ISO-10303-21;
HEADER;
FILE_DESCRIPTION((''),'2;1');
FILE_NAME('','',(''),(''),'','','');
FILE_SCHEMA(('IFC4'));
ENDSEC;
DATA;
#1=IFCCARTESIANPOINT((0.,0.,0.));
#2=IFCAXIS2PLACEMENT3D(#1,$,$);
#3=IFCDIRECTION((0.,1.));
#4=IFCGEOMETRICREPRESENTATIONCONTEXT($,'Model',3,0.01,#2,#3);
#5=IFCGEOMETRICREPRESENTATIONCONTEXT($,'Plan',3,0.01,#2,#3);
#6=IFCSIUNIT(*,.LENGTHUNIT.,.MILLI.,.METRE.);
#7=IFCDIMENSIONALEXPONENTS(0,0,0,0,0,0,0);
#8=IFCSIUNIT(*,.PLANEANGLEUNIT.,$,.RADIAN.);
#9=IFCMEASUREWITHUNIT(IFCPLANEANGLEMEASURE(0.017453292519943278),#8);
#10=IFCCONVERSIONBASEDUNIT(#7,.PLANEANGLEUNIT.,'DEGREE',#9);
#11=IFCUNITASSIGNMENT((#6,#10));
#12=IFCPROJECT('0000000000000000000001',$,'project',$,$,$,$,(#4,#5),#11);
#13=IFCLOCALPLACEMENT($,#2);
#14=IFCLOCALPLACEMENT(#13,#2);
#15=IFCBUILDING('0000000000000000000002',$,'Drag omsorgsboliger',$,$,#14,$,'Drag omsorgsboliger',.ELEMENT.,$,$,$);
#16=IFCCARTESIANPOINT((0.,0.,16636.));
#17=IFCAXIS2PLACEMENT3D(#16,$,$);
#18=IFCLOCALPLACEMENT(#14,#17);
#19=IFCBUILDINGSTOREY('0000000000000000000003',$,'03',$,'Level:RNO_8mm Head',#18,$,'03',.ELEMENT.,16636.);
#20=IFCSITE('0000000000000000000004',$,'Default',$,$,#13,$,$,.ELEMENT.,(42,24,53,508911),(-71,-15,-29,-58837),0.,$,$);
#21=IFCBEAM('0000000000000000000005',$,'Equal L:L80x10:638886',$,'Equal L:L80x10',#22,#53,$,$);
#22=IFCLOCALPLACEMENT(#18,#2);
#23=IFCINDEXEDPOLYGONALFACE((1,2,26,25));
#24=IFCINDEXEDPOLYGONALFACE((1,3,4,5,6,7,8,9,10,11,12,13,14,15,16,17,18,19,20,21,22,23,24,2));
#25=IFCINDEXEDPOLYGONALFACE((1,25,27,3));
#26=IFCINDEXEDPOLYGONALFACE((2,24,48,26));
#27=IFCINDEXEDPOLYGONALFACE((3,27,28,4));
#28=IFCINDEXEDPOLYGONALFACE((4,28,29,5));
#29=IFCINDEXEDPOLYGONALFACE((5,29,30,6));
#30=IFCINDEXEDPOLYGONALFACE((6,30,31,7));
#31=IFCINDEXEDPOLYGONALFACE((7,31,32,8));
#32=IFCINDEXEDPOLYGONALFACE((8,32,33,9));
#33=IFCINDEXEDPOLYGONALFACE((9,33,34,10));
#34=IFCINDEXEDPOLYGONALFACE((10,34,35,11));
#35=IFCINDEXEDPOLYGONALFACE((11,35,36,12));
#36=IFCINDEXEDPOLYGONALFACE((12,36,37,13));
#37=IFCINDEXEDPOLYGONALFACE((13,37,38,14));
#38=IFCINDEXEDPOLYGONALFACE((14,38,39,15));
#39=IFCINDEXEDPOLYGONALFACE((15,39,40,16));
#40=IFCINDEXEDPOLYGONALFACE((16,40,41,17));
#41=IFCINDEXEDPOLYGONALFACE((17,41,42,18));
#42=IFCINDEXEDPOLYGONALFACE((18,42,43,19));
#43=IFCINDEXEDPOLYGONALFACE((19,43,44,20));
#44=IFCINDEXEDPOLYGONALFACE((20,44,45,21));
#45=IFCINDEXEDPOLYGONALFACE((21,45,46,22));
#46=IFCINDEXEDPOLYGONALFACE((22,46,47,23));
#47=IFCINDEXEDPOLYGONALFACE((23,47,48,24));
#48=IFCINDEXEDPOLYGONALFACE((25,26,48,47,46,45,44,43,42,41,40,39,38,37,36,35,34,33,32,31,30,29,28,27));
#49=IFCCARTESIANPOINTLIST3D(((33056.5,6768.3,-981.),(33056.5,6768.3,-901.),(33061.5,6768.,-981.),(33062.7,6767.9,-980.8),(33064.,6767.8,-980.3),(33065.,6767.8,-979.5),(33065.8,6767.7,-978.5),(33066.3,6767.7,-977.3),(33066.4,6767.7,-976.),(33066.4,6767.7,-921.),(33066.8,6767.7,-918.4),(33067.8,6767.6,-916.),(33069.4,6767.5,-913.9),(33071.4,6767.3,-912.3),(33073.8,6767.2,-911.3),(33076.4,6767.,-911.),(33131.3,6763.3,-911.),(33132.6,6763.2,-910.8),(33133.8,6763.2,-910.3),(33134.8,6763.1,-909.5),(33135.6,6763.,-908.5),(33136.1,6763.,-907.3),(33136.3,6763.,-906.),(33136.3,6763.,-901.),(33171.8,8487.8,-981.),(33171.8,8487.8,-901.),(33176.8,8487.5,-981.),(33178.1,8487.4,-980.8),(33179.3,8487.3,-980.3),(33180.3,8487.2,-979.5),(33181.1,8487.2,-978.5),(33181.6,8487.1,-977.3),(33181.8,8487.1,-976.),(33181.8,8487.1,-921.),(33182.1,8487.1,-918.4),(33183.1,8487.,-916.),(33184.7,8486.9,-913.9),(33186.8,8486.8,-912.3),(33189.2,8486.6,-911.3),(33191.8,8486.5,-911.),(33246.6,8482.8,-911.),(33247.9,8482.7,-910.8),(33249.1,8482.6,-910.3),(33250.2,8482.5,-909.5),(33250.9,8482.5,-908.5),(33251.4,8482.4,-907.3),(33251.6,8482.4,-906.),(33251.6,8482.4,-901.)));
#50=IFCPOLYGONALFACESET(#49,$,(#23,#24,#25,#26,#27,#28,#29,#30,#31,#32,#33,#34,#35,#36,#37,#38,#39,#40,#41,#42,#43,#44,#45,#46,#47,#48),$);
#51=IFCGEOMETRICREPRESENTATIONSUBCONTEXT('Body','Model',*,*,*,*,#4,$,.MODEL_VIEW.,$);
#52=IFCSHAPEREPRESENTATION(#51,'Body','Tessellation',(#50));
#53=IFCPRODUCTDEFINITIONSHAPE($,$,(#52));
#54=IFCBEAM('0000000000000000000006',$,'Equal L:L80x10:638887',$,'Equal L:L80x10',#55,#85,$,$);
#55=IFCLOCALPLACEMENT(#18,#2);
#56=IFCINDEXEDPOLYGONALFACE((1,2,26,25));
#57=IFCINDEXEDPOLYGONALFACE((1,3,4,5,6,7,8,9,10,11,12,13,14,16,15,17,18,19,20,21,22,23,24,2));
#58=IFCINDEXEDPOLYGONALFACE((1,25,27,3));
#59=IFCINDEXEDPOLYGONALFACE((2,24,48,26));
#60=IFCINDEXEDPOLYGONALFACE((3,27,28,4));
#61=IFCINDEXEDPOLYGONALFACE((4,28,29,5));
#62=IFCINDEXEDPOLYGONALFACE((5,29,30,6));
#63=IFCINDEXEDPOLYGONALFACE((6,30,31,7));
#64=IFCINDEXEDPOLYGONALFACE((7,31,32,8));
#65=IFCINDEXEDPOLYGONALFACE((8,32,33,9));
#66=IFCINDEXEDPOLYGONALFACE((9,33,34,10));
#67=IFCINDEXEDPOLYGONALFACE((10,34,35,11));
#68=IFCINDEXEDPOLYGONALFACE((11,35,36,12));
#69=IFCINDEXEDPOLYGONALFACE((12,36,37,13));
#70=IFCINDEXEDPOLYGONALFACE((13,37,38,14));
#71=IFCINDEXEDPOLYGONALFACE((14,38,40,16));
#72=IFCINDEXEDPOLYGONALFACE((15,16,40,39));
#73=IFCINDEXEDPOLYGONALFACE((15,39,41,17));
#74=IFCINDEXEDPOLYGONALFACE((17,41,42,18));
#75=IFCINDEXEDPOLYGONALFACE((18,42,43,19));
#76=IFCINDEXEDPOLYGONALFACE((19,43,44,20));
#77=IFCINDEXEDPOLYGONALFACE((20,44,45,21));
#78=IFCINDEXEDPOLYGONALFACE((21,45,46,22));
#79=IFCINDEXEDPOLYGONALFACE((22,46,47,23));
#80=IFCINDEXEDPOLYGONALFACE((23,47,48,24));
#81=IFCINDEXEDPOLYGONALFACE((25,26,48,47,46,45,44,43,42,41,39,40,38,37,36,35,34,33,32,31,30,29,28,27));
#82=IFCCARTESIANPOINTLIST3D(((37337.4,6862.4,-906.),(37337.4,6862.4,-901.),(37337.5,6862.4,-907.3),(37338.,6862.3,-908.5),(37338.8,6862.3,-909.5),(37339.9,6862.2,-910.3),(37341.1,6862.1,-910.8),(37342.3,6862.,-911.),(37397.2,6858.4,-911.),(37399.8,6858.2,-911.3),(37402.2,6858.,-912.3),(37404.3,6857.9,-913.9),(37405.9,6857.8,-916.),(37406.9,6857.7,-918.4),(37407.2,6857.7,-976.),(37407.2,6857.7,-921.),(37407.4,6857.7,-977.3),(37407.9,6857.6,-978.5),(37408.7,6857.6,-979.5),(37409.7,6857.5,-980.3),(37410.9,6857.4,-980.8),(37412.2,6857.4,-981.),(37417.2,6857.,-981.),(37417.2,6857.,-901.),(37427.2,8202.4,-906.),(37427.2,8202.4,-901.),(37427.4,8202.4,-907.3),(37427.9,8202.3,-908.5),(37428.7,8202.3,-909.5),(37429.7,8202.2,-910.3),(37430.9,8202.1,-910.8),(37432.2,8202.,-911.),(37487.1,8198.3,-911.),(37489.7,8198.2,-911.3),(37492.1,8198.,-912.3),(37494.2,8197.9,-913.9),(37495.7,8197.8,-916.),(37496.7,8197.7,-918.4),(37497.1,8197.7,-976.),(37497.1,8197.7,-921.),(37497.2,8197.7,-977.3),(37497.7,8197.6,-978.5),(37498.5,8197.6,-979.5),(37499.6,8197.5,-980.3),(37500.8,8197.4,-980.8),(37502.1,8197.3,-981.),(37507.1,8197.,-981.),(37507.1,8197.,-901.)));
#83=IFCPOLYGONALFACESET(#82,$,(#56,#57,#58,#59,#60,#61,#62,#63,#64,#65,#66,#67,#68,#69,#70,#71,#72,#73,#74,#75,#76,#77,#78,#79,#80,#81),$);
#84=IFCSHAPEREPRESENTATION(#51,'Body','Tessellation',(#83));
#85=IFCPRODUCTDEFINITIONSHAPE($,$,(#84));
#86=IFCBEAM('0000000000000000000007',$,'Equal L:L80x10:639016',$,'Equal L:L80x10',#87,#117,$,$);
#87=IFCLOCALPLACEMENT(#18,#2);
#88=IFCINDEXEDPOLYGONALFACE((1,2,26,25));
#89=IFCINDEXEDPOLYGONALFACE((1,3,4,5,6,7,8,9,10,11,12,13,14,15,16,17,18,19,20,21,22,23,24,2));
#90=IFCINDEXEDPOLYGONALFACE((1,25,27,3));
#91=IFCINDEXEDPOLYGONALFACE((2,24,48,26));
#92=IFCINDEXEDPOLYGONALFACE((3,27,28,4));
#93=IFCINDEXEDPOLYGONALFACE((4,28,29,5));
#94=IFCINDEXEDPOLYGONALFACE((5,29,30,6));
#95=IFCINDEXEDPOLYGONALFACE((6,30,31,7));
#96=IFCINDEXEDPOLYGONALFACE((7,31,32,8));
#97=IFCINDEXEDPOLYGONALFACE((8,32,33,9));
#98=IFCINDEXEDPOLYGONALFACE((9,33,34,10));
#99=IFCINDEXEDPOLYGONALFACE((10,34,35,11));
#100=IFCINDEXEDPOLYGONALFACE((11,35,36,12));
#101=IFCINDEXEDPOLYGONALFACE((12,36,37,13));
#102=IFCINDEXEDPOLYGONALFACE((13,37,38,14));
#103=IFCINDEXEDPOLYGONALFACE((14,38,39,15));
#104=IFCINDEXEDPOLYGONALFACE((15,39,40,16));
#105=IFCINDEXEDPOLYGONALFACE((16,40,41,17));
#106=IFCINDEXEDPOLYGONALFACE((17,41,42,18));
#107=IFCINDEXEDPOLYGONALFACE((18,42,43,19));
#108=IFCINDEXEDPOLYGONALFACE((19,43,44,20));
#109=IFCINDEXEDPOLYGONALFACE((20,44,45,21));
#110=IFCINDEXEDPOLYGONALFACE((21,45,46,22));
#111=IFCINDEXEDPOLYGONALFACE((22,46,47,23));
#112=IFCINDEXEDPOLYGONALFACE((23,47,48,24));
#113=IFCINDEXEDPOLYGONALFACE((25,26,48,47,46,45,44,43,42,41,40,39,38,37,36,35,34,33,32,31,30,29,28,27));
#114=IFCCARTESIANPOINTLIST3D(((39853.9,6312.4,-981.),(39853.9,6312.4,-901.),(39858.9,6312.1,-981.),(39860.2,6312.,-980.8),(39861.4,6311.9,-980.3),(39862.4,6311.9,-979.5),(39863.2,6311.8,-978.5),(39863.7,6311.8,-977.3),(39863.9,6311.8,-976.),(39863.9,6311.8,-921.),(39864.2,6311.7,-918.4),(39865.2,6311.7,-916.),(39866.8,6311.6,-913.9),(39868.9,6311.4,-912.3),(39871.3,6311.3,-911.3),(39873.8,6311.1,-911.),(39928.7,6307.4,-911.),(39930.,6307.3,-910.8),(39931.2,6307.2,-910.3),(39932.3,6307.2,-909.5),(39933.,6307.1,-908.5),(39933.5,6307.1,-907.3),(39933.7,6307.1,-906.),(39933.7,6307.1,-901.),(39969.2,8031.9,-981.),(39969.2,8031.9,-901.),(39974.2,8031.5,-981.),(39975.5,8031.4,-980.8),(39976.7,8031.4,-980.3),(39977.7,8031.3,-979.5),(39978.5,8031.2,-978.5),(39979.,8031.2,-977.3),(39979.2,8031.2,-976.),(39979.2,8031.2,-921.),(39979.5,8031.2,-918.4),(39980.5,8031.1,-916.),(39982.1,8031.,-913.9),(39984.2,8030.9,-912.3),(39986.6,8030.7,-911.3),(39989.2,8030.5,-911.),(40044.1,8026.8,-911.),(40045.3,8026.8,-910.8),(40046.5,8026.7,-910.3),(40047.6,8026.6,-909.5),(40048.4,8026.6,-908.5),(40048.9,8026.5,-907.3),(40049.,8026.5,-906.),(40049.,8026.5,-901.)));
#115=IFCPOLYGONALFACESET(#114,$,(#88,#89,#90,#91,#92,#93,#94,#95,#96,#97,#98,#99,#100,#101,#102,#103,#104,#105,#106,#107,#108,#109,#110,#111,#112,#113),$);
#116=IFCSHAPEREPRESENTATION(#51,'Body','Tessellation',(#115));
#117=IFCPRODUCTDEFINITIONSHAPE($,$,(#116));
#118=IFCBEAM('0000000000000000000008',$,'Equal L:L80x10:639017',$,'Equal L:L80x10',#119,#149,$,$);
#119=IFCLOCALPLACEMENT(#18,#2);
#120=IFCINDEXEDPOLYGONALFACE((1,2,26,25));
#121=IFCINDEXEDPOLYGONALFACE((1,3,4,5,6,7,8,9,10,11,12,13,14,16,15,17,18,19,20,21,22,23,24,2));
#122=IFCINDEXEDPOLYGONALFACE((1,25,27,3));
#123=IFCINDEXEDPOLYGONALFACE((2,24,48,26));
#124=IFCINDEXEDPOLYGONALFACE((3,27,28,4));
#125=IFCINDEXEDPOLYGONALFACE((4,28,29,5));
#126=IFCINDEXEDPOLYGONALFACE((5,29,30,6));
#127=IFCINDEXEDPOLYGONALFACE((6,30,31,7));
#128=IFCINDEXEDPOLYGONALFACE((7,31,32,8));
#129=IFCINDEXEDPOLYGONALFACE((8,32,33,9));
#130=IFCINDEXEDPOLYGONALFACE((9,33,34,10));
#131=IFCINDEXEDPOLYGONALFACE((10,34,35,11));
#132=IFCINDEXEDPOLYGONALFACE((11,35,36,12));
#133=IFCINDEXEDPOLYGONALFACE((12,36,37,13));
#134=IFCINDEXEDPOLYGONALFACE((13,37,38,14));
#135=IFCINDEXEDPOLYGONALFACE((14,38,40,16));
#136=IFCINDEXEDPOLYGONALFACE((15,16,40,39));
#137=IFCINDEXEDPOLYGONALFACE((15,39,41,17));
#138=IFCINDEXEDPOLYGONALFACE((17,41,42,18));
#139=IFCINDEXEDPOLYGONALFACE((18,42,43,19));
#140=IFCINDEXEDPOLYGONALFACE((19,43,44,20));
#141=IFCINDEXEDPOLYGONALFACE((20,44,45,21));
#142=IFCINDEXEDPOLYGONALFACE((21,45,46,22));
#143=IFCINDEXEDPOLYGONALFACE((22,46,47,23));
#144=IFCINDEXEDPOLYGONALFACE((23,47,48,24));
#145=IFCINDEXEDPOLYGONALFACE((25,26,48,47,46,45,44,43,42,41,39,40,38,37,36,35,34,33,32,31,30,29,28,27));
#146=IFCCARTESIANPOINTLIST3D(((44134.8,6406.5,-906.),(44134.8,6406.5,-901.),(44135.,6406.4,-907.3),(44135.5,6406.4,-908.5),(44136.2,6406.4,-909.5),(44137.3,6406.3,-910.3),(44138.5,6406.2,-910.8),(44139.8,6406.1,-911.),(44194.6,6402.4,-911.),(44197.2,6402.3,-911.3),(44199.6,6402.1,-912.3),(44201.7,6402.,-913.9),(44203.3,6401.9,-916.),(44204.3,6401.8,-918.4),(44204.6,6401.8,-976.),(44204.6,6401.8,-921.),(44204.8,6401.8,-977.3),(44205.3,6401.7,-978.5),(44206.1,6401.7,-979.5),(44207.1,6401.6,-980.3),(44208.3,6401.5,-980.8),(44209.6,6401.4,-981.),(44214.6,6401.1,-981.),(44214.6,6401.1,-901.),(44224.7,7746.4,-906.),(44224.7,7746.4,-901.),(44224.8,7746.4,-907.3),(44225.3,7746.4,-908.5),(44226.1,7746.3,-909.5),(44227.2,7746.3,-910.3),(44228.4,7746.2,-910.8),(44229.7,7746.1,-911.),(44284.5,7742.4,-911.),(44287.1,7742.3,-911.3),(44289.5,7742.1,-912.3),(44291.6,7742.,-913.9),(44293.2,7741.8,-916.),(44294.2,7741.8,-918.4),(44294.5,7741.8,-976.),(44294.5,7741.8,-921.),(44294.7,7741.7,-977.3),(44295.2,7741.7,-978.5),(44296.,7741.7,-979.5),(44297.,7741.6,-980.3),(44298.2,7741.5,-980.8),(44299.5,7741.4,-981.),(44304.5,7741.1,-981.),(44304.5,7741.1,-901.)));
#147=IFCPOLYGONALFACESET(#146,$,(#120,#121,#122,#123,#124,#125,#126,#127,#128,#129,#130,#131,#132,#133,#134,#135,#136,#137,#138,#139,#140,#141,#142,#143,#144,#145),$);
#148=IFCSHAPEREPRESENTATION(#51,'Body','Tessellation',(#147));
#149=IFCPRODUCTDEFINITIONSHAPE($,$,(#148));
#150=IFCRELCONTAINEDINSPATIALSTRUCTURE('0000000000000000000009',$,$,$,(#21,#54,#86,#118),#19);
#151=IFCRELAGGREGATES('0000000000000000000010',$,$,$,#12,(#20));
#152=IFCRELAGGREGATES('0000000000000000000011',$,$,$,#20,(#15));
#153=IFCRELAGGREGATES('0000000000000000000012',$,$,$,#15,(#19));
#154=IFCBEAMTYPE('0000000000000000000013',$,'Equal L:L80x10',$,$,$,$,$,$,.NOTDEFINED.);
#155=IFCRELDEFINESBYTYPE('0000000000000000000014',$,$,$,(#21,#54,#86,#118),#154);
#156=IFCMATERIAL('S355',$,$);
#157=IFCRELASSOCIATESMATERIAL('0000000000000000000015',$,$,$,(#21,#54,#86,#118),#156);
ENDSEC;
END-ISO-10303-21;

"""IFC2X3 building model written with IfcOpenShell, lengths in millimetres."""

from ifc_helpers import new_model, entity, si_unit, converted_unit, direction, frame, frame_2d, origin, place, context, subcontext, project, spatial, polyline, circle_curve, parameter, trimmed, segment, composite_curve, outline, extrude, material, type_object, element, save


model = new_model("IFC2X3")

# Units and contexts
model_context = context("Model", 3, precision=0.01, world=origin(), true_north=direction((0.0, 1.0)))
plan_context = context("Plan", 3, precision=0.01, world=origin(), true_north=direction((0.0, 1.0)))
body_context = subcontext(model_context, "Body", "Model", "MODEL_VIEW")
ifc_project = project(units=[si_unit("LENGTHUNIT", "METRE", prefix="MILLI"), converted_unit("PLANEANGLEUNIT", "DEGREE", entity("IfcPlaneAngleMeasure", 0.017453292519943278), si_unit("PLANEANGLEUNIT", "RADIAN"), dimensions=[0, 0, 0, 0, 0, 0, 0])], contexts=[model_context, plan_context])

# Site, building, storey
site_placement = place(None, origin())
site = spatial("IfcSite", under=ifc_project, at=site_placement, Name="Default", CompositionType="ELEMENT", RefLatitude=(42, 24, 53, 508911), RefLongitude=(-71, -15, -29, -58837), RefElevation=0.0)
building_placement = place(site_placement, origin())
building = spatial("IfcBuilding", under=site, at=building_placement, Name="Drag omsorgsboliger", LongName="Drag omsorgsboliger", CompositionType="ELEMENT")
storey_placement = place(building_placement, frame((0.0, 0.0, 16636.0)))
storey = spatial("IfcBuildingStorey", under=building, at=storey_placement, Name="03", ObjectType="Level:RNO_8mm Head", LongName="03", CompositionType="ELEMENT", Elevation=16636.0)

# Beams
ifc_material = material(Name="S355")
beam_type_1 = type_object("IfcBeamType", Name="Equal L:L80x10", PredefinedType="NOTDEFINED")
beam_1_placement = place(storey_placement, frame((33190.5, 8416.4, -981.0), z_axis=(0.0, 0.0, 1.0), x_axis=(-0.066923, -0.997758, 0.0)))
element("IfcBeam", 1, at=beam_1_placement, inside=storey, type_object=beam_type_1, material=ifc_material, Name="Equal L:L80x10:638886", ObjectType="Equal L:L80x10", context=body_context, shape_type="SweptSolid", body=[
    extrude(outline(composite_curve([segment(polyline([(-31.1, -31.1), (48.9, -31.1)]), True, "CONTINUOUS"), segment(polyline([(48.9, -31.1), (48.9, -26.1)]), True, "CONTINUOUS"), segment(trimmed(circle_curve(frame_2d((43.9, -26.1), x_axis=(1.0, 0.0)), 5.0), [parameter(0.0)], [parameter(90.0)], True, "PARAMETER"), True, "CONTINUOUS"), segment(polyline([(43.9, -21.1), (-11.1, -21.1)]), True, "CONTINUOUS"), segment(trimmed(circle_curve(frame_2d((-11.1, -11.1), x_axis=(0.0, -1.0)), 10.0), [parameter(270.0)], [parameter(0.0)], True, "PARAMETER"), False, "CONTINUOUS"), segment(polyline([(-21.1, -11.1), (-21.1, 43.9)]), True, "CONTINUOUS"), segment(trimmed(circle_curve(frame_2d((-26.1, 43.9), x_axis=(1.0, 0.0)), 5.0), [parameter(0.0)], [parameter(90.0)], True, "PARAMETER"), True, "CONTINUOUS"), segment(polyline([(-26.1, 48.9), (-31.1, 48.9)]), True, "CONTINUOUS"), segment(polyline([(-31.1, 48.9), (-31.1, -31.1)]), True, "CONTINUOUS")], self_intersect=False)), frame((-70.0, 7.7, 48.9), z_axis=(1.0, 0.0, 0.0), x_axis=(0.0, 0.0, -1.0)), (0.0, 0.0, 1.0), 1723.3),
])
beam_2_placement = place(storey_placement, frame((37484.4, 8208.6, -981.0), z_axis=(0.0, 0.0, 1.0), x_axis=(-0.066923, -0.997758, 0.0)))
element("IfcBeam", 2, at=beam_2_placement, inside=storey, type_object=beam_type_1, material=ifc_material, Name="Equal L:L80x10:638887", ObjectType="Equal L:L80x10", context=body_context, shape_type="SweptSolid", body=[
    extrude(outline(composite_curve([segment(polyline([(-31.1, -48.9), (-26.1, -48.9)]), True, "CONTINUOUS"), segment(trimmed(circle_curve(frame_2d((-26.1, -43.9), x_axis=(0.0, -1.0)), 5.0), [parameter(0.0)], [parameter(90.0)], True, "PARAMETER"), True, "CONTINUOUS"), segment(polyline([(-21.1, -43.9), (-21.1, 11.1)]), True, "CONTINUOUS"), segment(trimmed(circle_curve(frame_2d((-11.1, 11.1), x_axis=(-1.0, 0.0)), 10.0), [parameter(270.0)], [parameter(0.0)], True, "PARAMETER"), False, "CONTINUOUS"), segment(polyline([(-11.1, 21.1), (43.9, 21.1)]), True, "CONTINUOUS"), segment(trimmed(circle_curve(frame_2d((43.9, 26.1), x_axis=(0.0, -1.0)), 5.0), [parameter(0.0)], [parameter(90.0)], True, "PARAMETER"), True, "CONTINUOUS"), segment(polyline([(48.9, 26.1), (48.9, 31.1)]), True, "CONTINUOUS"), segment(polyline([(48.9, 31.1), (-31.1, 31.1)]), True, "CONTINUOUS"), segment(polyline([(-31.1, 31.1), (-31.1, -48.9)]), True, "CONTINUOUS")], self_intersect=False)), frame((10.0, -7.7, 48.9), z_axis=(1.0, 0.0, 0.0), x_axis=(0.0, 0.0, -1.0)), (0.0, 0.0, 1.0), 1343.0),
])
beam_3_placement = place(storey_placement, frame((39987.9, 7960.5, -981.0), z_axis=(0.0, 0.0, 1.0), x_axis=(-0.066923, -0.997758, 0.0)))
element("IfcBeam", 3, at=beam_3_placement, inside=storey, type_object=beam_type_1, material=ifc_material, Name="Equal L:L80x10:639016", ObjectType="Equal L:L80x10", context=body_context, shape_type="SweptSolid", body=[
    extrude(outline(composite_curve([segment(polyline([(-31.1, -31.1), (48.9, -31.1)]), True, "CONTINUOUS"), segment(polyline([(48.9, -31.1), (48.9, -26.1)]), True, "CONTINUOUS"), segment(trimmed(circle_curve(frame_2d((43.9, -26.1), x_axis=(1.0, 0.0)), 5.0), [parameter(0.0)], [parameter(90.0)], True, "PARAMETER"), True, "CONTINUOUS"), segment(polyline([(43.9, -21.1), (-11.1, -21.1)]), True, "CONTINUOUS"), segment(trimmed(circle_curve(frame_2d((-11.1, -11.1), x_axis=(0.0, -1.0)), 10.0), [parameter(270.0)], [parameter(0.0)], True, "PARAMETER"), False, "CONTINUOUS"), segment(polyline([(-21.1, -11.1), (-21.1, 43.9)]), True, "CONTINUOUS"), segment(trimmed(circle_curve(frame_2d((-26.1, 43.9), x_axis=(1.0, 0.0)), 5.0), [parameter(0.0)], [parameter(90.0)], True, "PARAMETER"), True, "CONTINUOUS"), segment(polyline([(-26.1, 48.9), (-31.1, 48.9)]), True, "CONTINUOUS"), segment(polyline([(-31.1, 48.9), (-31.1, -31.1)]), True, "CONTINUOUS")], self_intersect=False)), frame((-70.0, 7.7, 48.9), z_axis=(1.0, 0.0, 0.0), x_axis=(0.0, 0.0, -1.0)), (0.0, 0.0, 1.0), 1723.3),
])
beam_4_placement = place(storey_placement, frame((44281.8, 7752.6, -981.0), z_axis=(0.0, 0.0, 1.0), x_axis=(-0.066923, -0.997758, 0.0)))
element("IfcBeam", 4, at=beam_4_placement, inside=storey, type_object=beam_type_1, material=ifc_material, Name="Equal L:L80x10:639017", ObjectType="Equal L:L80x10", context=body_context, shape_type="SweptSolid", body=[
    extrude(outline(composite_curve([segment(polyline([(-31.1, -48.9), (-26.1, -48.9)]), True, "CONTINUOUS"), segment(trimmed(circle_curve(frame_2d((-26.1, -43.9), x_axis=(0.0, -1.0)), 5.0), [parameter(0.0)], [parameter(90.0)], True, "PARAMETER"), True, "CONTINUOUS"), segment(polyline([(-21.1, -43.9), (-21.1, 11.1)]), True, "CONTINUOUS"), segment(trimmed(circle_curve(frame_2d((-11.1, 11.1), x_axis=(-1.0, 0.0)), 10.0), [parameter(270.0)], [parameter(0.0)], True, "PARAMETER"), False, "CONTINUOUS"), segment(polyline([(-11.1, 21.1), (43.9, 21.1)]), True, "CONTINUOUS"), segment(trimmed(circle_curve(frame_2d((43.9, 26.1), x_axis=(0.0, -1.0)), 5.0), [parameter(0.0)], [parameter(90.0)], True, "PARAMETER"), True, "CONTINUOUS"), segment(polyline([(48.9, 26.1), (48.9, 31.1)]), True, "CONTINUOUS"), segment(polyline([(48.9, 31.1), (-31.1, 31.1)]), True, "CONTINUOUS"), segment(polyline([(-31.1, 31.1), (-31.1, -48.9)]), True, "CONTINUOUS")], self_intersect=False)), frame((10.0, -7.7, 48.9), z_axis=(1.0, 0.0, 0.0), x_axis=(0.0, 0.0, -1.0)), (0.0, 0.0, 1.0), 1343.0),
])

save(model, "model.ifc")
